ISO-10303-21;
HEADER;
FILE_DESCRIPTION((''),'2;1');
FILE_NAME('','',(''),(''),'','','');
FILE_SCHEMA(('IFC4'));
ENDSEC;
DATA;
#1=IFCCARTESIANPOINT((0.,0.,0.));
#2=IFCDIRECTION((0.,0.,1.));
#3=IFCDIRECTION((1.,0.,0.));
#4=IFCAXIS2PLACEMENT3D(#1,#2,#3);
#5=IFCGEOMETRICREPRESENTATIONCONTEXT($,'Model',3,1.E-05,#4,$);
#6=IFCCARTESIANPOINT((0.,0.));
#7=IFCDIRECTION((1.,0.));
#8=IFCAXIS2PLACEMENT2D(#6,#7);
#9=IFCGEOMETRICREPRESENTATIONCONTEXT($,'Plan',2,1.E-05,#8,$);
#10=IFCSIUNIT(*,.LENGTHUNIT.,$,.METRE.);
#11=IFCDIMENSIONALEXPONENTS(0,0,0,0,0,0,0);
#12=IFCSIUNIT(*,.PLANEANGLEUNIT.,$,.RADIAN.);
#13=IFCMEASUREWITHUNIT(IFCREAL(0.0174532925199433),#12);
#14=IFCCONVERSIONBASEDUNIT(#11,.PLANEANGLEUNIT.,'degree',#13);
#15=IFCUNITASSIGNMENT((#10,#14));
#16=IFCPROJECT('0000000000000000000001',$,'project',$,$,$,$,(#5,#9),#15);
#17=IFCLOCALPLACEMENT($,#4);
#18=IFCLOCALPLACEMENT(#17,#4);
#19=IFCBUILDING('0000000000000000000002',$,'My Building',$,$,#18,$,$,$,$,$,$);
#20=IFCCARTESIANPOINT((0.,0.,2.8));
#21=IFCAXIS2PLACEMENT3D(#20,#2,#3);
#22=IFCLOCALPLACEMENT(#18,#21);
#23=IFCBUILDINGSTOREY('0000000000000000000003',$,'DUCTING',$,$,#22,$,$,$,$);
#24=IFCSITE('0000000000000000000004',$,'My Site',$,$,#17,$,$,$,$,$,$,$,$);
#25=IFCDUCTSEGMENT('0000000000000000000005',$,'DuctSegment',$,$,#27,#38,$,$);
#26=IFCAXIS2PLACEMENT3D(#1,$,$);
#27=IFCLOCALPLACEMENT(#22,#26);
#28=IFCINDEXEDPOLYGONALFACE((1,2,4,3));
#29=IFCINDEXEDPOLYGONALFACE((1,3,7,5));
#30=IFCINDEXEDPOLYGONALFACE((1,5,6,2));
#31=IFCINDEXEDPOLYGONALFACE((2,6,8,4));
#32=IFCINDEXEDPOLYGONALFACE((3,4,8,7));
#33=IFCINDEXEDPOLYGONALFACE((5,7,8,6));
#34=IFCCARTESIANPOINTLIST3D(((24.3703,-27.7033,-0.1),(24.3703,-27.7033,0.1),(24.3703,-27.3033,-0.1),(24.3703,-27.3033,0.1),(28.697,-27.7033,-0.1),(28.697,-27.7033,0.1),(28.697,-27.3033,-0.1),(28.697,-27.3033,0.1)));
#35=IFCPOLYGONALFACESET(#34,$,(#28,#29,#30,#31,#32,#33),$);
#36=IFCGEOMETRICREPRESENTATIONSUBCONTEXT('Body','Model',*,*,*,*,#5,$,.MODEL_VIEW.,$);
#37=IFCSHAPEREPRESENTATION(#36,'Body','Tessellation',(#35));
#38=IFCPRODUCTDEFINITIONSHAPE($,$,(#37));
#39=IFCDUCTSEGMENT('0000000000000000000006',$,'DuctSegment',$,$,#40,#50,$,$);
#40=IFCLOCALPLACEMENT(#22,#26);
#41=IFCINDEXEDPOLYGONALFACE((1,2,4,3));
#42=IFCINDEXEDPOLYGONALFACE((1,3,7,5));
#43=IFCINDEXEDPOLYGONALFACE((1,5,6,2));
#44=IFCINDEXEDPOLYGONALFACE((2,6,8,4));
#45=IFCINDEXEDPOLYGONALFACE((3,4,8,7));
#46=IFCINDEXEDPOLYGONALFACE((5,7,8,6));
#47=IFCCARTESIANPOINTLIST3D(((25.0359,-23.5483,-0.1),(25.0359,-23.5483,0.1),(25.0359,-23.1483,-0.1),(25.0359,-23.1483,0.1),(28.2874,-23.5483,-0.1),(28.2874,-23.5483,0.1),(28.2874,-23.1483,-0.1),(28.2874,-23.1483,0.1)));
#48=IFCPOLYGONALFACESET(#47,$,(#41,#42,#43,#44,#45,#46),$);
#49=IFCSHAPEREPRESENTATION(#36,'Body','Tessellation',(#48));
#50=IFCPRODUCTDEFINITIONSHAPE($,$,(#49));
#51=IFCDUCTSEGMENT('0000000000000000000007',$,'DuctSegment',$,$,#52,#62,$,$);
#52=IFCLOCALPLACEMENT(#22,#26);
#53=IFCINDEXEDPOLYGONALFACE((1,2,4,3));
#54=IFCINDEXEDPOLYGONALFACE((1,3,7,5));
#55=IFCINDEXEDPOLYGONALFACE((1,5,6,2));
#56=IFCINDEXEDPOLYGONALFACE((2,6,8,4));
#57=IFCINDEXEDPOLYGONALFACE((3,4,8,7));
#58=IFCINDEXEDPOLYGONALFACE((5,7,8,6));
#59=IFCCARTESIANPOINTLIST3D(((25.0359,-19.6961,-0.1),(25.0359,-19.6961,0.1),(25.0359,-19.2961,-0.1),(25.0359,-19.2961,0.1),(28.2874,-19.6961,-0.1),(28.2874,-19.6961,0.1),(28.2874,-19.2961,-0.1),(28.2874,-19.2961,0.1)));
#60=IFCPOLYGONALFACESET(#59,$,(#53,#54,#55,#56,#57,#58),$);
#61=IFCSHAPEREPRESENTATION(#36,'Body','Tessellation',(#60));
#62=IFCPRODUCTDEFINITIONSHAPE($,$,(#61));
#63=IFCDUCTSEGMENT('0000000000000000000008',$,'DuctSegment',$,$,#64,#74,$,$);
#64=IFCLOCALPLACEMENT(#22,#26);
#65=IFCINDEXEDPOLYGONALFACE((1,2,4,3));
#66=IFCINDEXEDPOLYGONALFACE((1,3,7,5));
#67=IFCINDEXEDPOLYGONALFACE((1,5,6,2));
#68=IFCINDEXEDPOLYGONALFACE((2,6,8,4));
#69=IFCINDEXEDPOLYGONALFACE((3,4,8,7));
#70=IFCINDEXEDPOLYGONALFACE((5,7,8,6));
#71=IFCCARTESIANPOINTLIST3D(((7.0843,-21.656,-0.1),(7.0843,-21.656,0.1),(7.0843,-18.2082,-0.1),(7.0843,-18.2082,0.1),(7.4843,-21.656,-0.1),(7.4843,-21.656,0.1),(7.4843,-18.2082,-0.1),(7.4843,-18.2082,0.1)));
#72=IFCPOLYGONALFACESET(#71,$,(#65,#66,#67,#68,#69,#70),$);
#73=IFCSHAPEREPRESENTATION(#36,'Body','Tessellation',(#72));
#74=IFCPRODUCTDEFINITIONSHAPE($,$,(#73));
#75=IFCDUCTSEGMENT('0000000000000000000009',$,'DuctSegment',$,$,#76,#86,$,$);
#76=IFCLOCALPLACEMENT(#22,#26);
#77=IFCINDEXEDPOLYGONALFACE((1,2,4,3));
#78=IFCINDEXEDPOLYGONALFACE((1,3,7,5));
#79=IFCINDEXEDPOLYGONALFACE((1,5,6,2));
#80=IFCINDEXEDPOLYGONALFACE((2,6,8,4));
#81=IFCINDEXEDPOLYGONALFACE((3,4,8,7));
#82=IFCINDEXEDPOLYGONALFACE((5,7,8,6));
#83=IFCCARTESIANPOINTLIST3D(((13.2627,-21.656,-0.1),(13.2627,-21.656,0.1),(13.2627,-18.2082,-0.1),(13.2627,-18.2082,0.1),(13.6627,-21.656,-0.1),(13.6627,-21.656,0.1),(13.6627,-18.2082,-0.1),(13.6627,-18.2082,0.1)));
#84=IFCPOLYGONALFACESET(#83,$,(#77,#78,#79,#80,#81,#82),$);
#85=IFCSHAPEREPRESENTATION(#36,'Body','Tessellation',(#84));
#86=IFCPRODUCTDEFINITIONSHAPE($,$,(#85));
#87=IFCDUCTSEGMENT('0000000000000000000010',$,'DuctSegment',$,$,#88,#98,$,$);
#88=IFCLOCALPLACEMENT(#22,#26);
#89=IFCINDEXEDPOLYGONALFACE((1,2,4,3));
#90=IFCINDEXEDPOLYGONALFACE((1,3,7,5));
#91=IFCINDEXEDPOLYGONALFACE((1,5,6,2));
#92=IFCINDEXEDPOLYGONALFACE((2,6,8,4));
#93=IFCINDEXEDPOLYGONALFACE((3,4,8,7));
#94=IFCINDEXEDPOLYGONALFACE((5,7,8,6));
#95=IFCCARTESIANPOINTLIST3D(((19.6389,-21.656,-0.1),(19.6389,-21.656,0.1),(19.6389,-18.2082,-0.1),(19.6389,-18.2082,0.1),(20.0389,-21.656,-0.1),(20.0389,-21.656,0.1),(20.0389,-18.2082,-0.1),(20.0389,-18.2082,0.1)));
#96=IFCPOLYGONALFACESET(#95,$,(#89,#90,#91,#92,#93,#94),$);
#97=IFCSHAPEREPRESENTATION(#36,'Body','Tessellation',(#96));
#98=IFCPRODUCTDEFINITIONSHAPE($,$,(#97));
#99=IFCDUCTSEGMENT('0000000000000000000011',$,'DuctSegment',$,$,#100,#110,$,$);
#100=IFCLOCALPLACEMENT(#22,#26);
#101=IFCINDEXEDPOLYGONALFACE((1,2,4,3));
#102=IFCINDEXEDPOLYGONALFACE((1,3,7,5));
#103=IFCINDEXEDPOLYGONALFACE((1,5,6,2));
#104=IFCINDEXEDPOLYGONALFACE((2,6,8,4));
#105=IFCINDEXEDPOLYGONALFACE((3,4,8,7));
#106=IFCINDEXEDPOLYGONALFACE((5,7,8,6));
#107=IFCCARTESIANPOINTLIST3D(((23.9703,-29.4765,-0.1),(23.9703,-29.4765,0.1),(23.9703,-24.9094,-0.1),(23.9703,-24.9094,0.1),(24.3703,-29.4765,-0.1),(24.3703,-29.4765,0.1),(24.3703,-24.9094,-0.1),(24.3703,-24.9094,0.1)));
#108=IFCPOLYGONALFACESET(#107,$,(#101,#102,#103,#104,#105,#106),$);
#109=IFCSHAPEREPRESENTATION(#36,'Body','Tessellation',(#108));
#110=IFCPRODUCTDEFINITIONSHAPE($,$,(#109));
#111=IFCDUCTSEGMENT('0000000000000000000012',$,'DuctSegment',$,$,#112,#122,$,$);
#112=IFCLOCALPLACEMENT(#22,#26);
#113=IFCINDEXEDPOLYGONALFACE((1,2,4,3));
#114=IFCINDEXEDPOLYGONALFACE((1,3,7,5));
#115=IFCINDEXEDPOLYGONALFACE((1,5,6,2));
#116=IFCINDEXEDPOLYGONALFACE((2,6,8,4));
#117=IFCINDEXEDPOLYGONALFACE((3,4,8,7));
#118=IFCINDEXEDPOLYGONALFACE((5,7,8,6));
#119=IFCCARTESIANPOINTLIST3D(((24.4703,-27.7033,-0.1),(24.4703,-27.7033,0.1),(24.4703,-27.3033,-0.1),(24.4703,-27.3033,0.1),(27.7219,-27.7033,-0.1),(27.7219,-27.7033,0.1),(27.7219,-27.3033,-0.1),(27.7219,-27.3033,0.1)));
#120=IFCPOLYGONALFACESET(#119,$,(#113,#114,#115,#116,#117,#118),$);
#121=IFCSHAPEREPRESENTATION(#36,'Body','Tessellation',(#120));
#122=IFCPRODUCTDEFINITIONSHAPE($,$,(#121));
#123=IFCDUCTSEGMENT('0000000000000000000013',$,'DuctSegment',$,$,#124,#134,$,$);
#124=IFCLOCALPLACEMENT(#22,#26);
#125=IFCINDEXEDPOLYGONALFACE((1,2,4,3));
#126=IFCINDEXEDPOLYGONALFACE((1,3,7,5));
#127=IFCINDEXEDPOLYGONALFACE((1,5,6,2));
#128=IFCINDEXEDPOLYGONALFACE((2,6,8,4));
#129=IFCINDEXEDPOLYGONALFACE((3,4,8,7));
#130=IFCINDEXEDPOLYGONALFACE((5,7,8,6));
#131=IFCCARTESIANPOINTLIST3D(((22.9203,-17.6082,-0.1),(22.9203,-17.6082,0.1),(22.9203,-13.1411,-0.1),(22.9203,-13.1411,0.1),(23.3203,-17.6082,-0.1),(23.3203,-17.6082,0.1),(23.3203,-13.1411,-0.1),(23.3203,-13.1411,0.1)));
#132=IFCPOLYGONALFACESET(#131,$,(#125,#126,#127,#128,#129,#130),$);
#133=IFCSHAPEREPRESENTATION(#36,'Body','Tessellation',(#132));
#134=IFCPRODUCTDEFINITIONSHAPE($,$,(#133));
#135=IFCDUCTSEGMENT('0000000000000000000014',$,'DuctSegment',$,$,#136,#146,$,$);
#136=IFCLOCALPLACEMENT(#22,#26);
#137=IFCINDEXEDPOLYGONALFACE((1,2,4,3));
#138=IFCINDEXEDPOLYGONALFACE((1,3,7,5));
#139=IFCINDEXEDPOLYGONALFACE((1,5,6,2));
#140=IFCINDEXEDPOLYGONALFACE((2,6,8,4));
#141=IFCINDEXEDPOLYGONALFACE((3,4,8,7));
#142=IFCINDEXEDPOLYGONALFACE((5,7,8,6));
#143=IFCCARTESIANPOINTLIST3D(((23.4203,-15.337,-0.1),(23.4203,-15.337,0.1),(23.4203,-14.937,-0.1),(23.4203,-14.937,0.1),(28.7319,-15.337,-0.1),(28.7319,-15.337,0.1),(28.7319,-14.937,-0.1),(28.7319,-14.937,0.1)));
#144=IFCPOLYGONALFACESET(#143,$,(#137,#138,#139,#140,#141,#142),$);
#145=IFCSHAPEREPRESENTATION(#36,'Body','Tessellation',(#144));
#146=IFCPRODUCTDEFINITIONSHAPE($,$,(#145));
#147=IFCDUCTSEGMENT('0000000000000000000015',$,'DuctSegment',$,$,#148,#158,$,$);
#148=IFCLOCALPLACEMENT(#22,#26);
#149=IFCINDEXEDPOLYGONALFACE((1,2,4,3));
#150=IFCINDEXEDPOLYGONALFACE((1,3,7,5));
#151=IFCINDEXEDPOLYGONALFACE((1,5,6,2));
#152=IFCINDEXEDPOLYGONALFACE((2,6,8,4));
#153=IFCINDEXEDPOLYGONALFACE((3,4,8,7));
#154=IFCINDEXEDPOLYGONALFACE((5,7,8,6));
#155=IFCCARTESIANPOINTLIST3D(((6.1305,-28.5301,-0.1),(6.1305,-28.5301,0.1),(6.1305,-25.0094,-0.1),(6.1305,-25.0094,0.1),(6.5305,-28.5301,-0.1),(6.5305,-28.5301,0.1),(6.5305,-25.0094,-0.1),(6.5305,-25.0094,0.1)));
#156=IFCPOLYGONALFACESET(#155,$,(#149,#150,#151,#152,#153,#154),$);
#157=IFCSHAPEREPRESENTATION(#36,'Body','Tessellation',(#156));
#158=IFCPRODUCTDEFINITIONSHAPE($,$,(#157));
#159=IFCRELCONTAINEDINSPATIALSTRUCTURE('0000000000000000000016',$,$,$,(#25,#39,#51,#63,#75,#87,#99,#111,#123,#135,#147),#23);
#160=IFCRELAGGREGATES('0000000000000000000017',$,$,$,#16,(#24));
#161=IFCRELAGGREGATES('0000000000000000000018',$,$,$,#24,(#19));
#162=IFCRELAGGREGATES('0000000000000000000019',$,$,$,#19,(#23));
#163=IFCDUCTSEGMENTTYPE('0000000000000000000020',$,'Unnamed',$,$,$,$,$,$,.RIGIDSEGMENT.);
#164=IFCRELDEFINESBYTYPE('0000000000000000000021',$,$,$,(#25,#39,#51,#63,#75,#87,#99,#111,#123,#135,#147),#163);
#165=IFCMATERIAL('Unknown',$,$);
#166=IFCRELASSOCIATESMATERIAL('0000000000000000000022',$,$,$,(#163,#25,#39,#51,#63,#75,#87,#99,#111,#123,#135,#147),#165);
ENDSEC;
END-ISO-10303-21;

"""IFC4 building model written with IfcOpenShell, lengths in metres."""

from ifc_helpers import new_model, entity, si_unit, converted_unit, frame, origin_with_axes, origin_2d_with_axis, place, context, subcontext, project, spatial, rectangle, extrude, material, material_profile, profile_set, profile_usage, type_object, element, save


model = new_model("IFC4")

# Units and contexts
model_context = context("Model", 3, precision=1e-05, world=origin_with_axes())
plan_context = context("Plan", 2, precision=1e-05, world=origin_2d_with_axis())
body_context = subcontext(model_context, "Body", "Model", "MODEL_VIEW")
ifc_project = project(units=[si_unit("LENGTHUNIT", "METRE"), converted_unit("PLANEANGLEUNIT", "degree", entity("IfcReal", 0.0174532925199433), si_unit("PLANEANGLEUNIT", "RADIAN"), dimensions=[0, 0, 0, 0, 0, 0, 0])], contexts=[model_context, plan_context])

# Site, building, storey
site_placement = place(None, origin_with_axes())
site = spatial("IfcSite", under=ifc_project, at=site_placement, Name="My Site")
building_placement = place(site_placement, origin_with_axes())
building = spatial("IfcBuilding", under=site, at=building_placement, Name="My Building")
storey_placement = place(building_placement, frame((0.0, 0.0, 2.8), z_axis=(0.0, 0.0, 1.0), x_axis=(1.0, 0.0, 0.0)))
storey = spatial("IfcBuildingStorey", under=building, at=storey_placement, Name="DUCTING")

# Duct segments
ifc_material = material(Name="Unknown")
ifc_material_profile = material_profile(ifc_material, rectangle(XDim=0.4, YDim=0.2))
ifc_profile_set = profile_set([ifc_material_profile])
duct_segment_type = type_object("IfcDuctSegmentType", Name="Unnamed", PredefinedType="RIGIDSEGMENT", material=ifc_profile_set)
ifc_profile_usage_1 = profile_usage(ifc_profile_set, cardinal=5)
duct_segment_1_placement = place(storey_placement, frame((24.3703, -27.5033, 0.0), z_axis=(1.0, 0.0, 0.0), x_axis=(0.0, 1.0, 0.0)))
element("IfcDuctSegment", 1, at=duct_segment_1_placement, inside=storey, type_object=duct_segment_type, material=ifc_profile_usage_1, Name="DuctSegment", context=body_context, shape_type="SweptSolid", body=[
    extrude(rectangle(XDim=0.4, YDim=0.2), origin_with_axes(), (0.0, 0.0, 1.0), 4.3267),
])
ifc_profile_usage_2 = profile_usage(ifc_profile_set, cardinal=5)
duct_segment_2_placement = place(storey_placement, frame((25.0359, -23.3483, 0.0), z_axis=(1.0, 0.0, 0.0), x_axis=(0.0, 1.0, 0.0)))
element("IfcDuctSegment", 2, at=duct_segment_2_placement, inside=storey, type_object=duct_segment_type, material=ifc_profile_usage_2, Name="DuctSegment", context=body_context, shape_type="SweptSolid", body=[
    extrude(rectangle(XDim=0.4, YDim=0.2), origin_with_axes(), (0.0, 0.0, 1.0), 3.2516),
])
ifc_profile_usage_3 = profile_usage(ifc_profile_set, cardinal=5)
duct_segment_3_placement = place(storey_placement, frame((25.0359, -19.4961, 0.0), z_axis=(1.0, 0.0, 0.0), x_axis=(0.0, 1.0, 0.0)))
element("IfcDuctSegment", 3, at=duct_segment_3_placement, inside=storey, type_object=duct_segment_type, material=ifc_profile_usage_3, Name="DuctSegment", context=body_context, shape_type="SweptSolid", body=[
    extrude(rectangle(XDim=0.4, YDim=0.2), origin_with_axes(), (0.0, 0.0, 1.0), 3.2516),
])
ifc_profile_usage_4 = profile_usage(ifc_profile_set, cardinal=5)
duct_segment_4_placement = place(storey_placement, frame((7.2843, -21.656, 0.0), z_axis=(0.0, 1.0, 0.0), x_axis=(-1.0, 0.0, 0.0)))
element("IfcDuctSegment", 4, at=duct_segment_4_placement, inside=storey, type_object=duct_segment_type, material=ifc_profile_usage_4, Name="DuctSegment", context=body_context, shape_type="SweptSolid", body=[
    extrude(rectangle(XDim=0.4, YDim=0.2), origin_with_axes(), (0.0, 0.0, 1.0), 3.4478),
])
ifc_profile_usage_5 = profile_usage(ifc_profile_set, cardinal=5)
duct_segment_5_placement = place(storey_placement, frame((13.4627, -21.656, 0.0), z_axis=(0.0, 1.0, 0.0), x_axis=(-1.0, 0.0, 0.0)))
element("IfcDuctSegment", 5, at=duct_segment_5_placement, inside=storey, type_object=duct_segment_type, material=ifc_profile_usage_5, Name="DuctSegment", context=body_context, shape_type="SweptSolid", body=[
    extrude(rectangle(XDim=0.4, YDim=0.2), origin_with_axes(), (0.0, 0.0, 1.0), 3.4478),
])
ifc_profile_usage_6 = profile_usage(ifc_profile_set, cardinal=5)
duct_segment_6_placement = place(storey_placement, frame((19.8389, -21.656, 0.0), z_axis=(0.0, 1.0, 0.0), x_axis=(-1.0, 0.0, 0.0)))
element("IfcDuctSegment", 6, at=duct_segment_6_placement, inside=storey, type_object=duct_segment_type, material=ifc_profile_usage_6, Name="DuctSegment", context=body_context, shape_type="SweptSolid", body=[
    extrude(rectangle(XDim=0.4, YDim=0.2), origin_with_axes(), (0.0, 0.0, 1.0), 3.4478),
])
ifc_profile_usage_7 = profile_usage(ifc_profile_set, cardinal=5)
duct_segment_7_placement = place(storey_placement, frame((24.1703, -24.9094, 0.0), z_axis=(0.0, -1.0, 0.0), x_axis=(1.0, 0.0, 0.0)))
element("IfcDuctSegment", 7, at=duct_segment_7_placement, inside=storey, type_object=duct_segment_type, material=ifc_profile_usage_7, Name="DuctSegment", context=body_context, shape_type="SweptSolid", body=[
    extrude(rectangle(XDim=0.4, YDim=0.2), origin_with_axes(), (0.0, 0.0, 1.0), 4.5671),
])
ifc_profile_usage_8 = profile_usage(ifc_profile_set, cardinal=5)
duct_segment_8_placement = place(storey_placement, frame((24.4703, -27.5033, 0.0), z_axis=(1.0, 0.0, 0.0), x_axis=(0.0, 1.0, 0.0)))
element("IfcDuctSegment", 8, at=duct_segment_8_placement, inside=storey, type_object=duct_segment_type, material=ifc_profile_usage_8, Name="DuctSegment", context=body_context, shape_type="SweptSolid", body=[
    extrude(rectangle(XDim=0.4, YDim=0.2), origin_with_axes(), (0.0, 0.0, 1.0), 3.2516),
])
ifc_profile_usage_9 = profile_usage(ifc_profile_set, cardinal=5)
duct_segment_9_placement = place(storey_placement, frame((23.1203, -17.6082, 0.0), z_axis=(0.0, 1.0, 0.0), x_axis=(-1.0, 0.0, 0.0)))
element("IfcDuctSegment", 9, at=duct_segment_9_placement, inside=storey, type_object=duct_segment_type, material=ifc_profile_usage_9, Name="DuctSegment", context=body_context, shape_type="SweptSolid", body=[
    extrude(rectangle(XDim=0.4, YDim=0.2), origin_with_axes(), (0.0, 0.0, 1.0), 4.4671),
])
ifc_profile_usage_10 = profile_usage(ifc_profile_set, cardinal=5)
duct_segment_10_placement = place(storey_placement, frame((23.4203, -15.137, 0.0), z_axis=(1.0, 0.0, 0.0), x_axis=(0.0, 1.0, 0.0)))
element("IfcDuctSegment", 10, at=duct_segment_10_placement, inside=storey, type_object=duct_segment_type, material=ifc_profile_usage_10, Name="DuctSegment", context=body_context, shape_type="SweptSolid", body=[
    extrude(rectangle(XDim=0.4, YDim=0.2), origin_with_axes(), (0.0, 0.0, 1.0), 5.3116),
])
ifc_profile_usage_11 = profile_usage(ifc_profile_set, cardinal=5)
duct_segment_11_placement = place(storey_placement, frame((6.3305, -25.0094, 0.0), z_axis=(0.0, -1.0, 0.0), x_axis=(1.0, 0.0, 0.0)))
element("IfcDuctSegment", 11, at=duct_segment_11_placement, inside=storey, type_object=duct_segment_type, material=ifc_profile_usage_11, Name="DuctSegment", context=body_context, shape_type="SweptSolid", body=[
    extrude(rectangle(XDim=0.4, YDim=0.2), origin_with_axes(), (0.0, 0.0, 1.0), 3.5207),
])

save(model, "model.ifc")
